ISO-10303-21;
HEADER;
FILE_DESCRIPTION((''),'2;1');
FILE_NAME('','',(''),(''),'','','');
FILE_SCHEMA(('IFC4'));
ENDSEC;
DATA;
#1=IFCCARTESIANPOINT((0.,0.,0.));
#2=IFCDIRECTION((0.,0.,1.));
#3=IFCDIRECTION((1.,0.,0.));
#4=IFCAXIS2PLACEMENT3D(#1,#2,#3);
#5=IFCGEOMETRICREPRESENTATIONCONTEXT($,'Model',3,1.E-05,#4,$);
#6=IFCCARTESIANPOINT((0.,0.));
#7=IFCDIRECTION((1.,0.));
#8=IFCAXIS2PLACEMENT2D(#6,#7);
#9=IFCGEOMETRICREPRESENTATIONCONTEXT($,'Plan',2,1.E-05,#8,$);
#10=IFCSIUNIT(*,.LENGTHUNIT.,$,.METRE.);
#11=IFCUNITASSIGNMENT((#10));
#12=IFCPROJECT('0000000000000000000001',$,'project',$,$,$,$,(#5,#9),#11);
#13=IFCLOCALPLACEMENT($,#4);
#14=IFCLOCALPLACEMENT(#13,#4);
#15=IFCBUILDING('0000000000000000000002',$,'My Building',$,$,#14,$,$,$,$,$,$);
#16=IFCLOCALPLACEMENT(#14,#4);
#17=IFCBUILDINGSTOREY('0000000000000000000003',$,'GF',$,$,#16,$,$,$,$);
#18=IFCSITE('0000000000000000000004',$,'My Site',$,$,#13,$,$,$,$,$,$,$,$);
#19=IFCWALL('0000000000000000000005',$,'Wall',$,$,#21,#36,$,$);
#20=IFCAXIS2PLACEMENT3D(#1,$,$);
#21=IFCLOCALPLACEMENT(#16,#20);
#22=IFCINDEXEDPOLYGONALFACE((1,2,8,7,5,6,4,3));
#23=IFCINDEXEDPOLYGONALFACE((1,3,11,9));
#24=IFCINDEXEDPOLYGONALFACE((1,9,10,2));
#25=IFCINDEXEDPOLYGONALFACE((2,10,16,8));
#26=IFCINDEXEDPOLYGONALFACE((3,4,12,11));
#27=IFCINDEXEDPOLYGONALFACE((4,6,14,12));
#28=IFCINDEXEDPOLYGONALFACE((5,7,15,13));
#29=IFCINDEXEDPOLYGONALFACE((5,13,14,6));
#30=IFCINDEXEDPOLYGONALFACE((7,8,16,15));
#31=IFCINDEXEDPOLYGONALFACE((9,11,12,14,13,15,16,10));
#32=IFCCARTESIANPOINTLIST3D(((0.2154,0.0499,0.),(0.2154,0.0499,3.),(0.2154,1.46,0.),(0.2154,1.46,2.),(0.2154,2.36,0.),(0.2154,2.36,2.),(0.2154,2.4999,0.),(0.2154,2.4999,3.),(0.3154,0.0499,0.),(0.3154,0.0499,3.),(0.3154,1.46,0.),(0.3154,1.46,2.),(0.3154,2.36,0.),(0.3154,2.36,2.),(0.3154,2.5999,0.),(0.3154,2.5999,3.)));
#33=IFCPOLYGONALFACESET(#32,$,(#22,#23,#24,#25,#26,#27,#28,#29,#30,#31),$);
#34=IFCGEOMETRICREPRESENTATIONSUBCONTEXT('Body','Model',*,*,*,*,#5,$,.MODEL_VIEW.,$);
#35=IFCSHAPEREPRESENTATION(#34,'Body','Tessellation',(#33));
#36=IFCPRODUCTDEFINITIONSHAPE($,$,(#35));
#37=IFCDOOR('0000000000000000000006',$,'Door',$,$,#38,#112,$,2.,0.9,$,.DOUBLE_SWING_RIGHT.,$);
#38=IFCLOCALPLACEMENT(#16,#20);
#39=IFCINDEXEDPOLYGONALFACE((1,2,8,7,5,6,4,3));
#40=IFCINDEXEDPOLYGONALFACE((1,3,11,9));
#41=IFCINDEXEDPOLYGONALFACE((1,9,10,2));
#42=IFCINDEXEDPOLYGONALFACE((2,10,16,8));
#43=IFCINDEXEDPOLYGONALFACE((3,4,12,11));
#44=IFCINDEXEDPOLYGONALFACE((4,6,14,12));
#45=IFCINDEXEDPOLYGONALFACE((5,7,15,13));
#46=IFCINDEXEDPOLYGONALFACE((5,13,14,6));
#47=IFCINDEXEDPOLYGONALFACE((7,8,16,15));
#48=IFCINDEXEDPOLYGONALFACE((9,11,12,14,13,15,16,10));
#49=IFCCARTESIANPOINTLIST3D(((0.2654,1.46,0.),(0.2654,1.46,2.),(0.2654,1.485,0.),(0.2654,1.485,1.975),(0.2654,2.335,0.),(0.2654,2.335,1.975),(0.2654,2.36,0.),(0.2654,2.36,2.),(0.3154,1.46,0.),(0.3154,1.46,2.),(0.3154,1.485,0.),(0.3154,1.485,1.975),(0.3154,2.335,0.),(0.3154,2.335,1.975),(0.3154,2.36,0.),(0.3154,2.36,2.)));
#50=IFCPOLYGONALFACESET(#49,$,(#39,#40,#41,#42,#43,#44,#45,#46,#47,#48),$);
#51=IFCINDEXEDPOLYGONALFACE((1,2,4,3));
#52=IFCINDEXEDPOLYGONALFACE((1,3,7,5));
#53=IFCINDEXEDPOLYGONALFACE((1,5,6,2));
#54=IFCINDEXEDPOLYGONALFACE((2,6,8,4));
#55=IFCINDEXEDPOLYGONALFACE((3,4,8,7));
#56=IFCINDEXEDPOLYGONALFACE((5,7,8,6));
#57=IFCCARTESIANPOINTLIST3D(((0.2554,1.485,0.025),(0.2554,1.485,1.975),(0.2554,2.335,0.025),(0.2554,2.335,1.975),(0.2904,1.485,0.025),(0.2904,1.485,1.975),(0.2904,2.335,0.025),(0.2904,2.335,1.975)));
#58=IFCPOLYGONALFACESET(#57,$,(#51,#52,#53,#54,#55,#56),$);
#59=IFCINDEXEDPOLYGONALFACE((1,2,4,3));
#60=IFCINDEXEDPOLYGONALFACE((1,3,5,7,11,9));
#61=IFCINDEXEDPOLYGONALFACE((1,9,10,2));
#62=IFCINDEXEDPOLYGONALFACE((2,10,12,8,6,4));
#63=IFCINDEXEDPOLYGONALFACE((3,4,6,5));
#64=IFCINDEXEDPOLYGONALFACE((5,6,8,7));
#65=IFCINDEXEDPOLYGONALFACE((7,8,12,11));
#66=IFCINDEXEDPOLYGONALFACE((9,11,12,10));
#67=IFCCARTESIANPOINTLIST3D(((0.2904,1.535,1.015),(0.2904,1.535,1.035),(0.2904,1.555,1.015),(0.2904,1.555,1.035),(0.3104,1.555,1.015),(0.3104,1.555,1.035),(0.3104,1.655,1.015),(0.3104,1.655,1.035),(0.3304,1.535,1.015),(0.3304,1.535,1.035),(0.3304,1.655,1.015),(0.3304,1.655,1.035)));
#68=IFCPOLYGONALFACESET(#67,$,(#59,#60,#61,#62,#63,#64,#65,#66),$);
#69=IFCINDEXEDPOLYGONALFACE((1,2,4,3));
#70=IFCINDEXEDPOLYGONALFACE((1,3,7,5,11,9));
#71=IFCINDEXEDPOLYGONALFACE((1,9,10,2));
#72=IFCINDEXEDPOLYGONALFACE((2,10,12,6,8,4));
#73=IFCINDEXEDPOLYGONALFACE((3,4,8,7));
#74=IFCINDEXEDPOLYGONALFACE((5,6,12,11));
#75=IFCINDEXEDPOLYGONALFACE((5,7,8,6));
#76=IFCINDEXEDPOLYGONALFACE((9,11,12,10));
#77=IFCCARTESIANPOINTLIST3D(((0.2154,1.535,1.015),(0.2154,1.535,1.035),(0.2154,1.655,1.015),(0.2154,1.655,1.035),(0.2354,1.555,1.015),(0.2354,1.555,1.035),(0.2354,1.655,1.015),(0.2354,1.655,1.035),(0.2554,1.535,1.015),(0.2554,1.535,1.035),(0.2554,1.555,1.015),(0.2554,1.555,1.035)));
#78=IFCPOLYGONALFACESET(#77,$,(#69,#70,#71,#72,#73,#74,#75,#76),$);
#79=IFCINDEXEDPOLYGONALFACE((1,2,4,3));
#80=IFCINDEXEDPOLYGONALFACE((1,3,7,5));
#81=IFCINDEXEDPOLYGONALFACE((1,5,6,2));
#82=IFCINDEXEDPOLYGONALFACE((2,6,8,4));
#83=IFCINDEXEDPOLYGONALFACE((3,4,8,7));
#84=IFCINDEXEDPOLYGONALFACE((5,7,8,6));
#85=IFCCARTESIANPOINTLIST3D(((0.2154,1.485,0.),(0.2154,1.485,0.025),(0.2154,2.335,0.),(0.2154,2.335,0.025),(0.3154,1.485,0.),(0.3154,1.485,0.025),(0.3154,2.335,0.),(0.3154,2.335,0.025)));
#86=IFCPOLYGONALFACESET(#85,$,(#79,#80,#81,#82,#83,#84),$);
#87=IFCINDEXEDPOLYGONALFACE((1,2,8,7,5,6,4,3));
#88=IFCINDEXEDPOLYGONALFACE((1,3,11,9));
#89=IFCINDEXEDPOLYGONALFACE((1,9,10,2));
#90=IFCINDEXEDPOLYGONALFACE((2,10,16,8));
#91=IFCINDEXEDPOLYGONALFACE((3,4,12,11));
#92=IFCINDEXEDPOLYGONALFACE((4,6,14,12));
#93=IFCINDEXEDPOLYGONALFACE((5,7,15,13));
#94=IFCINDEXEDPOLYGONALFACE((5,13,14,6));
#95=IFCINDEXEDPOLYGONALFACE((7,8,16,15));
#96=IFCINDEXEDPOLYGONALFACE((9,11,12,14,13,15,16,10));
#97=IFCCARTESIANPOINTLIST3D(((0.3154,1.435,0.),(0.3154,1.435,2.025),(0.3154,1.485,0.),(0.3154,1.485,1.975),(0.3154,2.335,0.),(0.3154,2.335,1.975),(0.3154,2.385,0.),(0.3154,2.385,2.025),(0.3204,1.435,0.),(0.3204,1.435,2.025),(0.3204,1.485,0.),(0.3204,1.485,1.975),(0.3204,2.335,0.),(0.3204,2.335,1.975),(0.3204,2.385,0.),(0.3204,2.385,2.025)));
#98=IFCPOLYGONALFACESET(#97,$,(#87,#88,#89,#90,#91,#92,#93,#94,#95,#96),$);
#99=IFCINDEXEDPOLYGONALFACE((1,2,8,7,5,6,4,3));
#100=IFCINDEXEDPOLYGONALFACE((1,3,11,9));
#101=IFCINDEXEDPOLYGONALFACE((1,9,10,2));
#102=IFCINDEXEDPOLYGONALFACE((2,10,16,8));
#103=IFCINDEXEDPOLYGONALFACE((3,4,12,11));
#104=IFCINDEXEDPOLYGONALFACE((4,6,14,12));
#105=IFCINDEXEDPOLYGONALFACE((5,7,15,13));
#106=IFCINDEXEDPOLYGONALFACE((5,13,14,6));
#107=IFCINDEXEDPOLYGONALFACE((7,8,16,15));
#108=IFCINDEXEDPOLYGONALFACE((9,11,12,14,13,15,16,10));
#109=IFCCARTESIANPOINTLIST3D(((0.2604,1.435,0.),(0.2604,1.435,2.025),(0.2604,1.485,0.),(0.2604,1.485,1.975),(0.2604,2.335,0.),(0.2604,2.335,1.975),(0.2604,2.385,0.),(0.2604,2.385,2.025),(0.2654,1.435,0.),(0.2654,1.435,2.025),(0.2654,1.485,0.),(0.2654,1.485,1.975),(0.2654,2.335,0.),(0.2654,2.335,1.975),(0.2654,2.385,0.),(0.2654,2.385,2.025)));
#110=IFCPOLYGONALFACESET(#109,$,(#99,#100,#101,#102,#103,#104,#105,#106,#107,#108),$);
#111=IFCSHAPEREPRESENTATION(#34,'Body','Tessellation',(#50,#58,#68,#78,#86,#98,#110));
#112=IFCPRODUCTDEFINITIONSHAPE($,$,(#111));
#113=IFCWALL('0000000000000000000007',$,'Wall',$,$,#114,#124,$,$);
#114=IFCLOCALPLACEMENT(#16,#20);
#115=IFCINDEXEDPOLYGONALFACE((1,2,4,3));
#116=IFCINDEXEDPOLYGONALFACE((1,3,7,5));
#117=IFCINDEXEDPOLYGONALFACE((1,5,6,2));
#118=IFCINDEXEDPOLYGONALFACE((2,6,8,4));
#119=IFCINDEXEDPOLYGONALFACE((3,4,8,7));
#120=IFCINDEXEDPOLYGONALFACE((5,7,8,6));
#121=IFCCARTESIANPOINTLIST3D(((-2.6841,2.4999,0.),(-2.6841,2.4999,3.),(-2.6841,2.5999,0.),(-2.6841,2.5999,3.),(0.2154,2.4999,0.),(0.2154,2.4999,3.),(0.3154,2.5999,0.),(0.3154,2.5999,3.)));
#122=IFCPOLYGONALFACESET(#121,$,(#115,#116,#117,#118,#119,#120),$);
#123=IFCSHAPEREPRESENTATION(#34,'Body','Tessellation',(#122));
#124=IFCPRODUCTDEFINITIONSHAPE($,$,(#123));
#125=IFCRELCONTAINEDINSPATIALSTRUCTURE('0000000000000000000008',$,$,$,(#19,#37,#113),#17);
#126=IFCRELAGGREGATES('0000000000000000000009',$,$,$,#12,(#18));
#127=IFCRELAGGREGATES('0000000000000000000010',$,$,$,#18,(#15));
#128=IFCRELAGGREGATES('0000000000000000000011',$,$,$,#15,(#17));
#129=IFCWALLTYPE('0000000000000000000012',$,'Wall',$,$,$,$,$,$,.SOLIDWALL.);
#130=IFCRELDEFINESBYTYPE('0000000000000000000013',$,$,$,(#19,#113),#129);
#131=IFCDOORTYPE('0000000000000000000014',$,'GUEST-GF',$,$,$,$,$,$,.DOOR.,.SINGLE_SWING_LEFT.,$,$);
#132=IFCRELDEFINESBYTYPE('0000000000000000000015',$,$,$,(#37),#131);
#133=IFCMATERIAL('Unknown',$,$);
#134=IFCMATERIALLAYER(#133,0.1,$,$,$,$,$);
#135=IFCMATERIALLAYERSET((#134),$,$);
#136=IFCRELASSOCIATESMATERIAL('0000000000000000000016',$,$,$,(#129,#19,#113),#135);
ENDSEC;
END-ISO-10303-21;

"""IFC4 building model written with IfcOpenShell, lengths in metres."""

from ifc_helpers import new_model, entity, si_unit, frame, origin_with_axes, origin_2d_with_axis, place, context, subcontext, project, spatial, line, indexed_curve, outline, extrude, shape, source, transform, mapped, material, layer, layer_set, layer_usage, type_object, type_shapes, element, fill, save


model = new_model("IFC4")

# Units and contexts
model_context = context("Model", 3, precision=1e-05, world=origin_with_axes())
plan_context = context("Plan", 2, precision=1e-05, world=origin_2d_with_axis())
body_context_1 = subcontext(model_context, "Body", "Model", "MODEL_VIEW")
body_context_2 = subcontext(plan_context, "Body", "Plan", "PLAN_VIEW")
ifc_project = project(units=[si_unit("LENGTHUNIT", "METRE")], contexts=[model_context, plan_context])

# Site, building, storey
site_placement = place(None, origin_with_axes())
site = spatial("IfcSite", under=ifc_project, at=site_placement, Name="My Site")
building_placement = place(site_placement, origin_with_axes())
building = spatial("IfcBuilding", under=site, at=building_placement, Name="My Building")
storey_placement = place(building_placement, origin_with_axes())
storey = spatial("IfcBuildingStorey", under=building, at=storey_placement, Name="GF")

# Shared definitions
ifc_material = material(Name="Unknown")

# Shared definitions
ifc_layer_1 = layer(ifc_material, 0.1)
ifc_layer_set_1 = layer_set([ifc_layer_1])
wall_type = type_object("IfcWallType", Name="Wall", PredefinedType="SOLIDWALL", material=ifc_layer_set_1)

# Wall, opening, door
ifc_layer_usage_1 = layer_usage(ifc_layer_set_1, "AXIS2", "POSITIVE", 0.0)
wall_1_placement = place(storey_placement, frame((0.3154, 0.0499, 0.0), z_axis=(0.0, 0.0, 1.0), x_axis=(0.0, 1.0, 0.0)))
wall_1 = element("IfcWall", 1, at=wall_1_placement, inside=storey, type_object=wall_type, material=ifc_layer_usage_1, Name="Wall", context=body_context_1, shape_type="SweptSolid", body=[
    extrude(outline(indexed_curve([(0.0, 0.0), (0.0, 0.1), (2.45, 0.1), (2.55, 0.0)], segments=[line(1, 2, 3, 4, 1)])), origin_with_axes(), (0.0, 0.0, 1.0), 3.0),
])
shared_shape_1 = source(origin_with_axes(), body_context_1, "Body", "SweptSolid", [
    extrude(outline(indexed_curve([(0.0, 0.0), (0.9, 0.0), (0.9, 2.0), (0.0, 2.0)], segments=[line(1, 2, 3, 4, 1)])), frame((0.0, -0.6, 0.0), z_axis=(0.0, -1.0, 0.0), x_axis=(1.0, 0.0, 0.0)), (0.0, 0.0, -1.0), 1.2),
])
opening_1_placement = place(wall_1_placement, frame((1.4101, 0.0, 0.0), z_axis=(0.0, 0.0, 1.0), x_axis=(1.0, 0.0, 0.0)))
opening_1 = element("IfcOpeningElement", 2, at=opening_1_placement, cuts=wall_1, PredefinedType="OPENING", context=body_context_1, shape_type="MappedRepresentation", body=[
    mapped(shared_shape_1, transform((0.0, 0.0, 0.0), x_axis=(1.0, 0.0, 0.0), y_axis=(0.0, 1.0, 0.0), z_axis=(0.0, 0.0, 1.0), scale=1.0)),
])
door_type_1 = type_object("IfcDoorType", Name="GUEST-GF", OperationType="SINGLE_SWING_LEFT", PredefinedType="DOOR")
shared_shape_2 = source(origin_with_axes(), body_context_1, "Body", "SweptSolid", [
    extrude(outline(indexed_curve([(0.0, 0.0), (0.0, 2.0), (0.9, 2.0), (0.9, 0.0), (0.875, 0.0), (0.875, 1.975), (0.025, 1.975), (0.025, 0.0)], segments=[line(1, 2, 3, 4, 5, 6, 7, 8, 1)])), frame((0.0, 0.0, 0.0), z_axis=(0.0, -1.0, 0.0), x_axis=(1.0, 0.0, 0.0)), (0.0, 0.0, -1.0), 0.05),
    extrude(outline(indexed_curve([(0.0, 0.0), (0.85, 0.0), (0.85, 0.035), (0.0, 0.035)], segments=[line(1, 2, 3, 4, 1)])), frame((0.025, 0.025, 0.025), z_axis=(0.0, 0.0, 1.0), x_axis=(1.0, 0.0, 0.0)), (0.0, 0.0, 1.0), 1.95),
    extrude(outline(indexed_curve([(0.0, 0.0), (0.0, -0.04), (0.12, -0.04), (0.12, -0.02), (0.02, -0.02), (0.02, 0.0)], segments=[line(1, 2, 3, 4, 5, 6, 1)])), frame((0.075, 0.025, 1.015), z_axis=(0.0, 0.0, 1.0), x_axis=(1.0, 0.0, 0.0)), (0.0, 0.0, 1.0), 0.02),
    extrude(outline(indexed_curve([(0.0, 0.0), (0.0, 0.04), (0.12, 0.04), (0.12, 0.02), (0.02, 0.02), (0.02, 0.0)], segments=[line(1, 2, 3, 4, 5, 6, 1)])), frame((0.075, 0.06, 1.015), z_axis=(0.0, 0.0, 1.0), x_axis=(1.0, 0.0, 0.0)), (0.0, 0.0, 1.0), 0.02),
    extrude(outline(indexed_curve([(0.0, 0.0), (0.85, 0.0), (0.85, 0.1), (0.0, 0.1)], segments=[line(1, 2, 3, 4, 1)])), frame((0.025, 0.0, 0.0), z_axis=(0.0, 0.0, 1.0), x_axis=(1.0, 0.0, 0.0)), (0.0, 0.0, 1.0), 0.025),
    extrude(outline(indexed_curve([(0.0, 0.0), (0.0, 2.025), (0.95, 2.025), (0.95, 0.0), (0.9, 0.0), (0.9, 1.975), (0.05, 1.975), (0.05, 0.0)], segments=[line(1, 2, 3, 4, 5, 6, 7, 8, 1)])), frame((-0.025, -0.005, 0.0), z_axis=(0.0, -1.0, 0.0), x_axis=(1.0, 0.0, 0.0)), (0.0, 0.0, -1.0), 0.005),
    extrude(outline(indexed_curve([(0.0, 0.0), (0.0, 2.025), (0.95, 2.025), (0.95, 0.0), (0.9, 0.0), (0.9, 1.975), (0.05, 1.975), (0.05, 0.0)], segments=[line(1, 2, 3, 4, 5, 6, 7, 8, 1)])), frame((-0.025, 0.05, 0.0), z_axis=(0.0, -1.0, 0.0), x_axis=(1.0, 0.0, 0.0)), (0.0, 0.0, -1.0), 0.005),
])
shared_shape_3 = source(origin_with_axes(), body_context_2, "Body", "Curve2D", [
    entity("IfcIndexedPolyCurve", entity("IfcCartesianPointList2D", [[0.0, 0.0], [0.025, 0.0], [0.025, 0.05], [0.0, 0.05]]), [entity("IfcLineIndex", [1, 2, 3, 4, 1])]),
    entity("IfcIndexedPolyCurve", entity("IfcCartesianPointList2D", [[0.9, 0.0], [0.875, 0.0], [0.875, 0.05], [0.9, 0.05]]), [entity("IfcLineIndex", [1, 2, 3, 4, 1])]),
    entity("IfcIndexedPolyCurve", entity("IfcCartesianPointList2D", [[0.875, 0.05], [0.875, -0.8], [0.84, -0.8]])),
    entity("IfcTrimmedCurve", entity("IfcEllipse", entity("IfcAxis2Placement2D", entity("IfcCartesianPoint", [0.84, 0.05]), entity("IfcDirection", [1.0, 0.0])), 0.815, 0.85), [entity("IfcCartesianPoint", [0.84, 0.9])], [entity("IfcCartesianPoint", [0.84, -0.8])], True, "CARTESIAN"),
    entity("IfcIndexedPolyCurve", entity("IfcCartesianPointList2D", [[0.875, 0.05], [0.84, 0.05], [0.84, 0.9], [0.875, 0.9]]), [entity("IfcLineIndex", [1, 2, 3, 4, 1])]),
])
type_shapes(door_type_1, [shared_shape_2, shared_shape_3])
door_1_placement = place(opening_1_placement, frame((0.0, 0.0, 0.0), z_axis=(0.0, 0.0, 1.0), x_axis=(1.0, 0.0, 0.0)))
door_1 = element("IfcDoor", 3, at=door_1_placement, inside=storey, type_object=door_type_1, Name="Door", OperationType="DOUBLE_SWING_RIGHT", OverallHeight=2.0, OverallWidth=0.9, shapes=[
    shape(body_context_1, "Body", "MappedRepresentation", [mapped(shared_shape_2, transform((0.0, 0.0, 0.0), x_axis=(1.0, 0.0, 0.0), y_axis=(0.0, 1.0, 0.0), z_axis=(0.0, 0.0, 1.0), scale=1.0))]),
    shape(body_context_2, "Body", "MappedRepresentation", [mapped(shared_shape_3, transform((0.0, 0.0, 0.0), x_axis=(1.0, 0.0, 0.0), y_axis=(0.0, 1.0, 0.0), z_axis=(0.0, 0.0, 1.0), scale=1.0))]),
])
fill(opening_1, door_1)

# Wall
ifc_layer_usage_2 = layer_usage(ifc_layer_set_1, "AXIS2", "POSITIVE", 0.0)
wall_2_placement = place(storey_placement, frame((0.3154, 2.5999, 0.0), z_axis=(0.0, 0.0, 1.0), x_axis=(-1.0, 0.0, 0.0)))
element("IfcWall", 4, at=wall_2_placement, inside=storey, type_object=wall_type, material=ifc_layer_usage_2, Name="Wall", context=body_context_1, shape_type="SweptSolid", body=[
    extrude(outline(indexed_curve([(0.0, 0.0), (0.1, 0.1), (2.9996, 0.1), (2.9996, 0.0)], segments=[line(1, 2, 3, 4, 1)])), origin_with_axes(), (0.0, 0.0, 1.0), 3.0),
])

save(model, "model.ifc")
